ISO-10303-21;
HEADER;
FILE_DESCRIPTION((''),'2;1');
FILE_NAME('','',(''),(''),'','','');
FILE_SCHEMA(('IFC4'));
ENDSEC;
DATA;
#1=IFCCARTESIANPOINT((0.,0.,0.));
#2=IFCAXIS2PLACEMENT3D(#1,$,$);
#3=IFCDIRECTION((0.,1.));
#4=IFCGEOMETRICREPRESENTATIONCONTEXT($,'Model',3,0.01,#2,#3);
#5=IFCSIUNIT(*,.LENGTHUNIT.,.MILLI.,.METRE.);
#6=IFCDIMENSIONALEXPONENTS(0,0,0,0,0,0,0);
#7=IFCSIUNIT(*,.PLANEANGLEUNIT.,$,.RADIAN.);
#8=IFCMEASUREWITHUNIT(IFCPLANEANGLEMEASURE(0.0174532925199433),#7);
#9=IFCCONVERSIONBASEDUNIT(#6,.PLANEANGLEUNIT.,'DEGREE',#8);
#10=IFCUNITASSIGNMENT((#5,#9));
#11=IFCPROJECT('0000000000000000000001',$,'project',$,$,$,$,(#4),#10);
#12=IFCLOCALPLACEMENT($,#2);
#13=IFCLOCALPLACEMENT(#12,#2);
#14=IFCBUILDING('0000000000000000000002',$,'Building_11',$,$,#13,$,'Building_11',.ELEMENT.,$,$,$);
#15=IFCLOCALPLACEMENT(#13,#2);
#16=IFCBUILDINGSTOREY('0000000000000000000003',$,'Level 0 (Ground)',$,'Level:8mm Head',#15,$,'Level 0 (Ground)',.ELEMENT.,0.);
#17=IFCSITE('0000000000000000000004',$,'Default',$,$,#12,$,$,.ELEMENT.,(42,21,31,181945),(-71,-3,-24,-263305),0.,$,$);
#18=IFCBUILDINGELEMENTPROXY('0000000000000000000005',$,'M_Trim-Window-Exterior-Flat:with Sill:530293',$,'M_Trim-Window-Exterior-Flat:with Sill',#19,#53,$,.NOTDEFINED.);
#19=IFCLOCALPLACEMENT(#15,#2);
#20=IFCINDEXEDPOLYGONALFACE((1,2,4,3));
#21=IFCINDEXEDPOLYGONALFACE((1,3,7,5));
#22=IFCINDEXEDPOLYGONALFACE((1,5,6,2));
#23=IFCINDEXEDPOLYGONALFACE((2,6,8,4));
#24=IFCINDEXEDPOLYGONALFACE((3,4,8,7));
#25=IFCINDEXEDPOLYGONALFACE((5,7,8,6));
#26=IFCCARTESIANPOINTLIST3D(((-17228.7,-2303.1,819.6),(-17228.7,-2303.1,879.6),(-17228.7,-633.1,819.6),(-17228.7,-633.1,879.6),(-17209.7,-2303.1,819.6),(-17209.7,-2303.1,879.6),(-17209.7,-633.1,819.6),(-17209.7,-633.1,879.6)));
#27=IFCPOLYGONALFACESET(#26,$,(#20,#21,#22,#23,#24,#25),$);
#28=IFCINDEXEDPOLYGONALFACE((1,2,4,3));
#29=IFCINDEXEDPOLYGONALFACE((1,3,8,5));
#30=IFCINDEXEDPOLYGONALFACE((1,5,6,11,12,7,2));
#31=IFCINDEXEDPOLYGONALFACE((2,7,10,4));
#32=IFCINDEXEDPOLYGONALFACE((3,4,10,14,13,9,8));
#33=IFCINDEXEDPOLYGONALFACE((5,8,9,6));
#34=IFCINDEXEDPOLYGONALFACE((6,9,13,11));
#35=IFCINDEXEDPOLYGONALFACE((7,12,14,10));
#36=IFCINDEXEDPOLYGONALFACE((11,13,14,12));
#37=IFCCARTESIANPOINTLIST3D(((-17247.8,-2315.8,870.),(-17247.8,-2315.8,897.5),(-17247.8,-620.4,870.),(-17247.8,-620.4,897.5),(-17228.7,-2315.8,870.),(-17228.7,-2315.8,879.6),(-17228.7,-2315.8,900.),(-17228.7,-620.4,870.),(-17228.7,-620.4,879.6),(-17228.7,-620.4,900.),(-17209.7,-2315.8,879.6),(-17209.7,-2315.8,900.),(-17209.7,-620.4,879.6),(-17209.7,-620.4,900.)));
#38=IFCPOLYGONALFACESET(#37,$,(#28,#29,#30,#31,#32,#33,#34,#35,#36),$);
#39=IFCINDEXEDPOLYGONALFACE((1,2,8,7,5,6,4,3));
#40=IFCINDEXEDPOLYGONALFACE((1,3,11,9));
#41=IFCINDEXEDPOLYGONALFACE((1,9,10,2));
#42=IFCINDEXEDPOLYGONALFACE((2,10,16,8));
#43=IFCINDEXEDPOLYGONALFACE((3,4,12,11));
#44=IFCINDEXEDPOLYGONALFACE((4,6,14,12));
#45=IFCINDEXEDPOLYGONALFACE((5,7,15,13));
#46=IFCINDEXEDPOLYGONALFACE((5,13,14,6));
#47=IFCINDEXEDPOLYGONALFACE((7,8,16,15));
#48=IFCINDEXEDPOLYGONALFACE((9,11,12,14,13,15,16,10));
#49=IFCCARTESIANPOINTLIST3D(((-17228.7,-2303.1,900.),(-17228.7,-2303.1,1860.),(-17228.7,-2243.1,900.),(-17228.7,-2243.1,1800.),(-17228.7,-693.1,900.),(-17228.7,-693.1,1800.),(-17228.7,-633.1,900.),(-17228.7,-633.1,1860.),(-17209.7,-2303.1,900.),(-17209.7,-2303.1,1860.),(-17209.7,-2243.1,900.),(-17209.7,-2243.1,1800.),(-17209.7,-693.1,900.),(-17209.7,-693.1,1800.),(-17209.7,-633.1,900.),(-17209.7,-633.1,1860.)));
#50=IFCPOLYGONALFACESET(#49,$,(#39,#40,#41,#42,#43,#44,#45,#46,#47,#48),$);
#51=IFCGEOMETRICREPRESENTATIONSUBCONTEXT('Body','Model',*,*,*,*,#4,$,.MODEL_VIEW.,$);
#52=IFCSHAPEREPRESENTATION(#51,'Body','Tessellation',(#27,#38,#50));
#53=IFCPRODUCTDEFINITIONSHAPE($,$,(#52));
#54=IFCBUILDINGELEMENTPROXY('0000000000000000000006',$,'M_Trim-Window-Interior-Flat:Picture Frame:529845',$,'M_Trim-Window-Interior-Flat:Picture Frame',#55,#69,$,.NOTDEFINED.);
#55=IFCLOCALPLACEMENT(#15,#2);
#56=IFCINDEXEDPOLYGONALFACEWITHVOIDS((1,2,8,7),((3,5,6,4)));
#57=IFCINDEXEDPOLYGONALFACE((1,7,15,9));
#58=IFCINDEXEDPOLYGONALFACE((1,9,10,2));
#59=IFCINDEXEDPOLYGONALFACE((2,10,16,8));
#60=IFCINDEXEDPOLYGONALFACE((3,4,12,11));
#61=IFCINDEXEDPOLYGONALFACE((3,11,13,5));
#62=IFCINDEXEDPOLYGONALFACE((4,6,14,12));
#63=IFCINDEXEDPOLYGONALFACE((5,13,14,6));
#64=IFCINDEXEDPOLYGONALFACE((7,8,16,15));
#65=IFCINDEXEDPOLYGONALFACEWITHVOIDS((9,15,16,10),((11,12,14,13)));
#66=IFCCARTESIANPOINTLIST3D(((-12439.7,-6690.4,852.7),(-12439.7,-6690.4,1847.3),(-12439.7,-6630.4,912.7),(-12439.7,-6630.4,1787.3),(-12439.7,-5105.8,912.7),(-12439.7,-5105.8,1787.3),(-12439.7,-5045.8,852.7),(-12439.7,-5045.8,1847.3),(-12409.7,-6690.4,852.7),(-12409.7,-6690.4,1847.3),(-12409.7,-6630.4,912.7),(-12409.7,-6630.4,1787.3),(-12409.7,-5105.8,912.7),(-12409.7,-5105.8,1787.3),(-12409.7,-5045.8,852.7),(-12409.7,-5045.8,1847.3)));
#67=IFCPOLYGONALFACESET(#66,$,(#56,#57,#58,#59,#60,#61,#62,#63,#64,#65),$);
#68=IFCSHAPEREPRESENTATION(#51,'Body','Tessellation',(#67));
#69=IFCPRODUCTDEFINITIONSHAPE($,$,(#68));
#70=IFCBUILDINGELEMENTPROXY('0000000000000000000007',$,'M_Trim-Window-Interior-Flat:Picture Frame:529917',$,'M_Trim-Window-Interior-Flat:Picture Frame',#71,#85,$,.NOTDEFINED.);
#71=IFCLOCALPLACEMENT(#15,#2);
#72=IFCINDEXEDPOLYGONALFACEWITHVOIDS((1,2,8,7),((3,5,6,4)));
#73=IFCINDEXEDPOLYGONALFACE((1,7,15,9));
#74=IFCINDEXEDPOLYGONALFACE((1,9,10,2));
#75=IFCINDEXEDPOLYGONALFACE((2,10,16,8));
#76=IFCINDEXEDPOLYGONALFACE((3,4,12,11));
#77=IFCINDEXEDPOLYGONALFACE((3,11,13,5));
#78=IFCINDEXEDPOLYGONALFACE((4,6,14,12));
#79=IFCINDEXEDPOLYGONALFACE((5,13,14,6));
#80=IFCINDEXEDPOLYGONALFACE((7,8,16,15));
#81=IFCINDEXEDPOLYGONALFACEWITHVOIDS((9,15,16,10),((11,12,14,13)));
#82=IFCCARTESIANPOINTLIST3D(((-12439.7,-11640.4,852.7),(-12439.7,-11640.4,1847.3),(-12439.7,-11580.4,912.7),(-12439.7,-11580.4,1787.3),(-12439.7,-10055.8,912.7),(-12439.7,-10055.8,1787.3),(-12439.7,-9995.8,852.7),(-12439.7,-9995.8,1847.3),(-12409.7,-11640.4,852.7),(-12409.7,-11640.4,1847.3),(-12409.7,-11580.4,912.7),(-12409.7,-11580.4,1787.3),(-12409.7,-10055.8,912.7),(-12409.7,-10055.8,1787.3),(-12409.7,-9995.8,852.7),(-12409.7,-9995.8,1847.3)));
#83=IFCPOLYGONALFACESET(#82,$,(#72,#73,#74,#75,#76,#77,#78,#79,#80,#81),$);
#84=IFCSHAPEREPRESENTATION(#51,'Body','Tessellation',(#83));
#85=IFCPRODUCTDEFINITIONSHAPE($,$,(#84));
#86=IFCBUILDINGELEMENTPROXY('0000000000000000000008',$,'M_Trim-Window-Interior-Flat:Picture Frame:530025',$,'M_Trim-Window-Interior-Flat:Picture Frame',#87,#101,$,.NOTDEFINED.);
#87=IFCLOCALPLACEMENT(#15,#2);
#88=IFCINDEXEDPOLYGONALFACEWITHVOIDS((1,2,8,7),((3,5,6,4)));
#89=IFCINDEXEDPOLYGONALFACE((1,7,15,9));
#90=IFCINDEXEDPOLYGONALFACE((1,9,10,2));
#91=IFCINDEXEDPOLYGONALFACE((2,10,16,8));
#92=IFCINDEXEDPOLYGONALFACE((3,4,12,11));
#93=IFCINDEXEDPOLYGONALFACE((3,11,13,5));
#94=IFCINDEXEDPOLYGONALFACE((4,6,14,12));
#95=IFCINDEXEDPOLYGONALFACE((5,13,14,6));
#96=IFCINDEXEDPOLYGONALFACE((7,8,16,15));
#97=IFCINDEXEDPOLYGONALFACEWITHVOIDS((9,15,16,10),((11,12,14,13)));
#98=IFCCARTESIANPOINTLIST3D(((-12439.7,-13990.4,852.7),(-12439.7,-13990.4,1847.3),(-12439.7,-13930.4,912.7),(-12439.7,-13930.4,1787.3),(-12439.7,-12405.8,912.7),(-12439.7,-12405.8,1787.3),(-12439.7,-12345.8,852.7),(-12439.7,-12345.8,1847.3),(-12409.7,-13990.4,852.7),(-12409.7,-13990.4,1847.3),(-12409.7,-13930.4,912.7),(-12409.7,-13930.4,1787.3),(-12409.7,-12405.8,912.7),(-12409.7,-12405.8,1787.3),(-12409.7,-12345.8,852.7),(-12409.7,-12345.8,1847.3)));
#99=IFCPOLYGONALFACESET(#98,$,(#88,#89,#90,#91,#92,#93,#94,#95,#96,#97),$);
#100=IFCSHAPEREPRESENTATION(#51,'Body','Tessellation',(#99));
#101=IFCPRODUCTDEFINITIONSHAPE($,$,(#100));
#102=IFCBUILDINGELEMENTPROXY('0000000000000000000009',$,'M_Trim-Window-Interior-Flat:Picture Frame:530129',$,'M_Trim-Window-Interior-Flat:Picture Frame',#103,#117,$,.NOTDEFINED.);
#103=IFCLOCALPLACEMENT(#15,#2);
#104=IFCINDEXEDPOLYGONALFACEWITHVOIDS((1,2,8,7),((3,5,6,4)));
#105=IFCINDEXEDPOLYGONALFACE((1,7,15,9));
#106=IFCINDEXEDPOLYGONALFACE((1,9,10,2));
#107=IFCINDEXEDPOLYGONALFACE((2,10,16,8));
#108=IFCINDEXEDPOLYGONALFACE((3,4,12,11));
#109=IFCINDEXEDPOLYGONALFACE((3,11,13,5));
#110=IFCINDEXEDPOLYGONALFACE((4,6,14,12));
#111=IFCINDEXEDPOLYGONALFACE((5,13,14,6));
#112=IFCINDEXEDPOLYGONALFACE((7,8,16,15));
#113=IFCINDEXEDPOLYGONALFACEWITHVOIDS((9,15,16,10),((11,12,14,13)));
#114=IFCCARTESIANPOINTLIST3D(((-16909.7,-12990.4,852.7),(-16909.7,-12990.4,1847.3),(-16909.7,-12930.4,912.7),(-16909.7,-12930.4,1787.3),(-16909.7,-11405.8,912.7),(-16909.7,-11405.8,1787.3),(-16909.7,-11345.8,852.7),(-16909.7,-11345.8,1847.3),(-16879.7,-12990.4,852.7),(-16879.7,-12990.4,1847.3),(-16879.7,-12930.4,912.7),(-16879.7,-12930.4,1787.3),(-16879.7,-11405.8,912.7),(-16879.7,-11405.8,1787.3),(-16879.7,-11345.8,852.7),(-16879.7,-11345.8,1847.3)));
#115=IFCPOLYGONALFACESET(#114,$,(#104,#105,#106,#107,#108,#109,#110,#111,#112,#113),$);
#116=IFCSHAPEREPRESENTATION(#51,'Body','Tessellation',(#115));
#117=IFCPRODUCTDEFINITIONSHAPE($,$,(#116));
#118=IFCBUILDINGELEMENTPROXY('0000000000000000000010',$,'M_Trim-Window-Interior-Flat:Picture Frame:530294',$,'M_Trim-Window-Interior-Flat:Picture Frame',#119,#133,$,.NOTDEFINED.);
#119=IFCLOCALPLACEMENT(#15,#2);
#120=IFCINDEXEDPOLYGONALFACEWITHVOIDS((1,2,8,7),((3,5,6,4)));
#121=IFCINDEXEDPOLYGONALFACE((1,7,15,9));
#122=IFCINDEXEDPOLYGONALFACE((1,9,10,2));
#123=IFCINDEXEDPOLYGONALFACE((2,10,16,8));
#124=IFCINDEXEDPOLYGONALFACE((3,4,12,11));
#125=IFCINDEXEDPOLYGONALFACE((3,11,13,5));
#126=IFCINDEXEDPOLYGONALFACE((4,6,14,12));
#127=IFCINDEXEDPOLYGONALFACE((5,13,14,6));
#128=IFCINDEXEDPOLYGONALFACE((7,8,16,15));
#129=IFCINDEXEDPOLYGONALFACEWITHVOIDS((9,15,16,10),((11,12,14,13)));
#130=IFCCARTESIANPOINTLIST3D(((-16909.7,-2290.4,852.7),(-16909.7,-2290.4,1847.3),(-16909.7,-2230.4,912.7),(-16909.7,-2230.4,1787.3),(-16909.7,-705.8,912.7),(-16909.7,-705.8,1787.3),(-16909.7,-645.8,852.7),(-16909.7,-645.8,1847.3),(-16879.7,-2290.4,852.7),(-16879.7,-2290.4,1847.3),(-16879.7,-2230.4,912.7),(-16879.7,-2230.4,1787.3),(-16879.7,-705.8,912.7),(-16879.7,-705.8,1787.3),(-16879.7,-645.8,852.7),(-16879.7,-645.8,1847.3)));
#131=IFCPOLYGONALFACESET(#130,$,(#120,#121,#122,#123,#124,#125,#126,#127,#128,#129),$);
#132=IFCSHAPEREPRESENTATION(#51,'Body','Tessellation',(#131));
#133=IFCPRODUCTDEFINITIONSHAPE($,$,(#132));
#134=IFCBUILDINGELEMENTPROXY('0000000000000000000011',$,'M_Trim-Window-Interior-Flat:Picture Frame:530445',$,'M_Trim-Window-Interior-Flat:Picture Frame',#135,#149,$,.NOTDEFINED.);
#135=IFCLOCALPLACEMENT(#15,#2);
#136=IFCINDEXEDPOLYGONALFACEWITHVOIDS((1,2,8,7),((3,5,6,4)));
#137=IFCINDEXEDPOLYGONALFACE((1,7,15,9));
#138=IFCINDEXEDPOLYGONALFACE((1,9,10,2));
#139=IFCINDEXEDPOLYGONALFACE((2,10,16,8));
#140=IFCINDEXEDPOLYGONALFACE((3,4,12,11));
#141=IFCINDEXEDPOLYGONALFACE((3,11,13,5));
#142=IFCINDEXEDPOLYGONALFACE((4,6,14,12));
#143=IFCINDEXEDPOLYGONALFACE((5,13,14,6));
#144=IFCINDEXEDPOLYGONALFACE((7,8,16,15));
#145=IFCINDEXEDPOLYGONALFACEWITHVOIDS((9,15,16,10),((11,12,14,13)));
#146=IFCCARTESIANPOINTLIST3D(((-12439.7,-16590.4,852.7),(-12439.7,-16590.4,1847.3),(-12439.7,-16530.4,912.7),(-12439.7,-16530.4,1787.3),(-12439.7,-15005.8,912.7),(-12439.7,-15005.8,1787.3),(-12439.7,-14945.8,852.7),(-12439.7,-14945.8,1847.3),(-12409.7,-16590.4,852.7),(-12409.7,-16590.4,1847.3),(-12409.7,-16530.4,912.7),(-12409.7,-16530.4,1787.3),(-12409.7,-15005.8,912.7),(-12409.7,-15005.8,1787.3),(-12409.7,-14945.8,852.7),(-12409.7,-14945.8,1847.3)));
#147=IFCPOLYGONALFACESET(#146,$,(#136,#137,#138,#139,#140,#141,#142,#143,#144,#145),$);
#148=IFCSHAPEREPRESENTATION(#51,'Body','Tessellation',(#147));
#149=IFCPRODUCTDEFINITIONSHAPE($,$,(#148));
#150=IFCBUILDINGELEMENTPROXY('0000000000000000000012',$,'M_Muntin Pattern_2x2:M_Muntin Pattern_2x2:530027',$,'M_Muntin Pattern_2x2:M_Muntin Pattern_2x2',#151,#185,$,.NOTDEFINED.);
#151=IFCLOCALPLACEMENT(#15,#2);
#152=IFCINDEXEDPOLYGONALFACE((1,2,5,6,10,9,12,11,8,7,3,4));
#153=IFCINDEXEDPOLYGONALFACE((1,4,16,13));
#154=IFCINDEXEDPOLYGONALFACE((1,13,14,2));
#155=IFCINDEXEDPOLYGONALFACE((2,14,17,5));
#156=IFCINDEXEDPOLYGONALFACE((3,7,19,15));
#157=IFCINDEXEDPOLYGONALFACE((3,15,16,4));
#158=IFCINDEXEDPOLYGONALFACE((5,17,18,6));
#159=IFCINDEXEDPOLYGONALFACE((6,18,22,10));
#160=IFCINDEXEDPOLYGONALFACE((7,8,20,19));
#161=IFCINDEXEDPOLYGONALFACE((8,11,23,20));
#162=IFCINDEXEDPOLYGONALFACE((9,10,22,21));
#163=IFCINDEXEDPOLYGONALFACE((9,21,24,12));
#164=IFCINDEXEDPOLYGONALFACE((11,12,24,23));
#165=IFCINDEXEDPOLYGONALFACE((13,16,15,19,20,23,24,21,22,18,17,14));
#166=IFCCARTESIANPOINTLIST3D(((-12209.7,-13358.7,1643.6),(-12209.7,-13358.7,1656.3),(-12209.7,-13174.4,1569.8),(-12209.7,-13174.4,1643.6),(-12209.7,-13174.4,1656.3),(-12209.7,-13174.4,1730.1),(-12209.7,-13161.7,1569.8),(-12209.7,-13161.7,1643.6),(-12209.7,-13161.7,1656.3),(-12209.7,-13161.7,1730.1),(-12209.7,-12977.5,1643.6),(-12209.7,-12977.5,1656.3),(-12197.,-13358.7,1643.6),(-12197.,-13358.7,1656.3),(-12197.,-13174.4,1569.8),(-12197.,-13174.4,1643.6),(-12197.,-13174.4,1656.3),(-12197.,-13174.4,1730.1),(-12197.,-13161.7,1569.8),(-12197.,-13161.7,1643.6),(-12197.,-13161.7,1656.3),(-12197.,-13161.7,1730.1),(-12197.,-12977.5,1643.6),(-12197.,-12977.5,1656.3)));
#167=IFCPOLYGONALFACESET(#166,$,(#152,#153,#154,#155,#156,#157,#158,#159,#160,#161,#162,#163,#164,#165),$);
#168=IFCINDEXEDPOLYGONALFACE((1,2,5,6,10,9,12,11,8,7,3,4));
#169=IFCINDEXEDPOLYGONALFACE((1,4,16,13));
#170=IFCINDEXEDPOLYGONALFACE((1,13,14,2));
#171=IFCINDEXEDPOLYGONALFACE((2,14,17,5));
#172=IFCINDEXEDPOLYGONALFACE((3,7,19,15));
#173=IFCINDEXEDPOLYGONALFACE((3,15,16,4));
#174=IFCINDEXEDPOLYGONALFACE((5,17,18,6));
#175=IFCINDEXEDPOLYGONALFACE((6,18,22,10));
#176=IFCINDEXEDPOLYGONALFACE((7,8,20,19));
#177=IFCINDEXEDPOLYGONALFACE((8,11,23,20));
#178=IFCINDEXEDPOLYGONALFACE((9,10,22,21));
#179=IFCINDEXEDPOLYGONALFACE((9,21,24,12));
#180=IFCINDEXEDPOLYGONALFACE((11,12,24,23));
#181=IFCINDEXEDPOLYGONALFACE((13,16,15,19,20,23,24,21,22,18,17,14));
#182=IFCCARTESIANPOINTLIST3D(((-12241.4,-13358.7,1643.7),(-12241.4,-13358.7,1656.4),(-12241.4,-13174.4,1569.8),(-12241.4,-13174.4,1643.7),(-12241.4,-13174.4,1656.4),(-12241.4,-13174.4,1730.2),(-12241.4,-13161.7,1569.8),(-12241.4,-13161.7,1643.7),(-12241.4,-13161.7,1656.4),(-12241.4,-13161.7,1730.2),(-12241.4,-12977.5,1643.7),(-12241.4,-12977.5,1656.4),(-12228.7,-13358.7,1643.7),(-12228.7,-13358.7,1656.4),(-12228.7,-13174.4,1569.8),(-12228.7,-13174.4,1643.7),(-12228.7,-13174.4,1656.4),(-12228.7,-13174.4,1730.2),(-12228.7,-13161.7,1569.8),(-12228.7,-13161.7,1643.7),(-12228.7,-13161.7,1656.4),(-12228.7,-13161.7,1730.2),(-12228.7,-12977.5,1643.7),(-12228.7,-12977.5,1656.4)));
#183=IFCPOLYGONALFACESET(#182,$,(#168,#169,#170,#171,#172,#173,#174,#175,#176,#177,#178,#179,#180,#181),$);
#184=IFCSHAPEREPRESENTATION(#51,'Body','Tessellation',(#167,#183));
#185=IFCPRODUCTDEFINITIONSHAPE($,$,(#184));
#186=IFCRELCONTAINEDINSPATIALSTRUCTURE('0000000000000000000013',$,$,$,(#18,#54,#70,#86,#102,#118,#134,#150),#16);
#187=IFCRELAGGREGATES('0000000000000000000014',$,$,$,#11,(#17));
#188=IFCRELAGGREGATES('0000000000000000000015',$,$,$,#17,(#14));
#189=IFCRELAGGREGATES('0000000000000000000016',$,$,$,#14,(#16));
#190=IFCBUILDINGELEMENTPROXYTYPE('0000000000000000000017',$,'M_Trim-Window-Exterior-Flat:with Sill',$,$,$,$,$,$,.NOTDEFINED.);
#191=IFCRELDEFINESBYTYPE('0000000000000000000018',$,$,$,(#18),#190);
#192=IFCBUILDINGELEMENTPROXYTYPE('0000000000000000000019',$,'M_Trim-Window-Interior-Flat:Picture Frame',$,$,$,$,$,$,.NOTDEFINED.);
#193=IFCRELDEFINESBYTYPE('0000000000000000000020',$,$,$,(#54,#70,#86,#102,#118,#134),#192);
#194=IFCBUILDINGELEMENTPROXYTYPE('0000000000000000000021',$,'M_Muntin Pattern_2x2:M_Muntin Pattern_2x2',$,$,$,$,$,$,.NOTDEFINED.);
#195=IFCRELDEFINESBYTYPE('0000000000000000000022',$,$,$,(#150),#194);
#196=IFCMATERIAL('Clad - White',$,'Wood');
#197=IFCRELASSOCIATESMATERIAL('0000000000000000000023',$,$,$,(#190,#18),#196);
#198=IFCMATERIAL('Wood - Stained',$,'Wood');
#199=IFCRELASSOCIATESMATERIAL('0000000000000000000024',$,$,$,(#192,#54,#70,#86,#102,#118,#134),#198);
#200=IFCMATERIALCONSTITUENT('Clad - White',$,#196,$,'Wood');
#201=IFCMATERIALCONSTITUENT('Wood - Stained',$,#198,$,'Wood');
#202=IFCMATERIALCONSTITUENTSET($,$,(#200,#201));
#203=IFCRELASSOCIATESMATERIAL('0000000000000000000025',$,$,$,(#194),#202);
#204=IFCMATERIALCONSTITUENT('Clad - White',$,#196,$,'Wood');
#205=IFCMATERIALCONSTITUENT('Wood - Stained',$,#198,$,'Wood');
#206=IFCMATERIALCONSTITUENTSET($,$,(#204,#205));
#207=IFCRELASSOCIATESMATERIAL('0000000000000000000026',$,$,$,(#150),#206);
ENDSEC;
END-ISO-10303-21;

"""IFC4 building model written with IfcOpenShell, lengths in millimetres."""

from ifc_helpers import new_model, entity, si_unit, converted_unit, direction, frame, origin, place, context, subcontext, project, spatial, indexed_curve, outline, extrude, source, transform, mapped, material, constituent, constituent_set, type_object, type_shapes, element, save


model = new_model("IFC4")

# Units and contexts
model_context = context("Model", 3, precision=0.01, world=origin(), true_north=direction((0.0, 1.0)))
body_context = subcontext(model_context, "Body", "Model", "MODEL_VIEW")
ifc_project = project(units=[si_unit("LENGTHUNIT", "METRE", prefix="MILLI"), converted_unit("PLANEANGLEUNIT", "DEGREE", entity("IfcPlaneAngleMeasure", 0.0174532925199433), si_unit("PLANEANGLEUNIT", "RADIAN"), dimensions=[0, 0, 0, 0, 0, 0, 0])], contexts=[model_context])

# Site, building, storey
site_placement = place(None, origin())
site = spatial("IfcSite", under=ifc_project, at=site_placement, Name="Default", CompositionType="ELEMENT", RefLatitude=(42, 21, 31, 181945), RefLongitude=(-71, -3, -24, -263305), RefElevation=0.0)
building_placement = place(site_placement, origin())
building = spatial("IfcBuilding", under=site, at=building_placement, Name="Building_11", LongName="Building_11", CompositionType="ELEMENT")
storey_placement = place(building_placement, origin())
storey = spatial("IfcBuildingStorey", under=building, at=storey_placement, Name="Level 0 (Ground)", ObjectType="Level:8mm Head", LongName="Level 0 (Ground)", CompositionType="ELEMENT", Elevation=0.0)

# Building element proxies
ifc_material_1 = material(Name="Clad - White", Category="Wood")
ifc_material_2 = material(Name="Wood - Stained", Category="Wood")
building_element_proxy_type_1 = type_object("IfcBuildingElementProxyType", Name="M_Trim-Window-Exterior-Flat:with Sill", PredefinedType="NOTDEFINED", material=ifc_material_1)
shared_shape_1 = source(origin(), body_context, "Body", "SweptSolid", [
    extrude(outline(indexed_curve([(-835.0, -30.0), (835.0, -30.0), (835.0, 30.0), (-835.0, 30.0), (-835.0, -30.0)], self_intersect=False)), frame((0.0, -950.4, 0.0), z_axis=(0.0, 0.0, 1.0), x_axis=(-1.0, 0.0, 0.0)), (0.0, 0.0, 1.0), 19.1),
    extrude(outline(indexed_curve([(-19.0, -15.2), (0.0, -15.2), (0.0, -5.7), (19.0, -5.7), (19.0, 14.8), (0.0, 14.8), (-19.0, 12.3), (-19.0, -15.2)], self_intersect=False)), frame((-847.7, -914.8, 19.0), z_axis=(1.0, 0.0, 0.0), x_axis=(0.0, 0.0, -1.0)), (0.0, 0.0, 1.0), 1695.4),
    extrude(outline(indexed_curve([(-495.0, -835.0), (465.0, -835.0), (465.0, -775.0), (-435.0, -775.0), (-435.0, 775.0), (465.0, 775.0), (465.0, 835.0), (-495.0, 835.0), (-495.0, -835.0)], self_intersect=False)), frame((0.0, -435.0, 0.0), z_axis=(0.0, 0.0, 1.0), x_axis=(0.0, -1.0, 0.0)), (0.0, 0.0, 1.0), 19.1),
])
type_shapes(building_element_proxy_type_1, [shared_shape_1])
for number, where, z_axis, x_axis, name in (
    (1, (-17209.7, -1468.1, 1800.0), (-1.0, 0.0, 0.0), (0.0, -1.0, 0.0), "M_Trim-Window-Exterior-Flat:with Sill:530293"),
):
    element("IfcBuildingElementProxy", number, at=place(storey_placement, frame(where, z_axis=z_axis, x_axis=x_axis)), inside=storey, type_object=building_element_proxy_type_1, material=ifc_material_1, Name=name, ObjectType="M_Trim-Window-Exterior-Flat:with Sill", PredefinedType="NOTDEFINED", context=body_context, shape_type="MappedRepresentation", body=[
        mapped(shared_shape_1, transform((0.0, 0.0, 0.0), scale=1.0)),
    ])
building_element_proxy_type_2 = type_object("IfcBuildingElementProxyType", Name="M_Trim-Window-Interior-Flat:Picture Frame", PredefinedType="NOTDEFINED", material=ifc_material_2)
shared_shape_2 = source(origin(), body_context, "Body", "SweptSolid", [
    extrude(outline(indexed_curve([(-822.3, -497.3), (822.3, -497.3), (822.3, 497.3), (-822.3, 497.3), (-822.3, -497.3)], self_intersect=False), holes=[indexed_curve([(-762.3, -437.3), (-762.3, 437.3), (762.3, 437.3), (762.3, -437.3), (-762.3, -437.3)], self_intersect=False)]), frame((0.0, -450.0, 0.0), z_axis=(0.0, 0.0, 1.0), x_axis=(-1.0, 0.0, 0.0)), (0.0, 0.0, 1.0), 30.0),
])
type_shapes(building_element_proxy_type_2, [shared_shape_2])
for number, where, z_axis, x_axis, name in (
    (2, (-12409.7, -5868.1, 1800.0), (-1.0, 0.0, 0.0), (0.0, -1.0, 0.0), "M_Trim-Window-Interior-Flat:Picture Frame:529845"),
    (3, (-12409.7, -10818.1, 1800.0), (-1.0, 0.0, 0.0), (0.0, -1.0, 0.0), "M_Trim-Window-Interior-Flat:Picture Frame:529917"),
    (4, (-12409.7, -13168.1, 1800.0), (-1.0, 0.0, 0.0), (0.0, -1.0, 0.0), "M_Trim-Window-Interior-Flat:Picture Frame:530025"),
    (5, (-16909.7, -12168.1, 1800.0), (1.0, 0.0, 0.0), (0.0, 1.0, 0.0), "M_Trim-Window-Interior-Flat:Picture Frame:530129"),
    (6, (-16909.7, -1468.1, 1800.0), (1.0, 0.0, 0.0), (0.0, 1.0, 0.0), "M_Trim-Window-Interior-Flat:Picture Frame:530294"),
    (7, (-12409.7, -15768.1, 1800.0), (-1.0, 0.0, 0.0), (0.0, -1.0, 0.0), "M_Trim-Window-Interior-Flat:Picture Frame:530445"),
):
    element("IfcBuildingElementProxy", number, at=place(storey_placement, frame(where, z_axis=z_axis, x_axis=x_axis)), inside=storey, type_object=building_element_proxy_type_2, material=ifc_material_2, Name=name, ObjectType="M_Trim-Window-Interior-Flat:Picture Frame", PredefinedType="NOTDEFINED", context=body_context, shape_type="MappedRepresentation", body=[
        mapped(shared_shape_2, transform((0.0, 0.0, 0.0), scale=1.0)),
    ])
ifc_constituent_1 = constituent(ifc_material_1, Name="Clad - White", Category="Wood")
ifc_constituent_2 = constituent(ifc_material_2, Name="Wood - Stained", Category="Wood")
ifc_constituent_set_1 = constituent_set(constituents=[ifc_constituent_1, ifc_constituent_2])
ifc_constituent_3 = constituent(ifc_material_1, Name="Clad - White", Category="Wood")
ifc_constituent_4 = constituent(ifc_material_2, Name="Wood - Stained", Category="Wood")
ifc_constituent_set_2 = constituent_set(constituents=[ifc_constituent_3, ifc_constituent_4])
building_element_proxy_type_3 = type_object("IfcBuildingElementProxyType", Name="M_Muntin Pattern_2x2:M_Muntin Pattern_2x2", PredefinedType="NOTDEFINED", material=ifc_constituent_set_2)
shared_shape_3 = source(origin(), body_context, "Body", "SweptSolid", [
    extrude(outline(indexed_curve([(6.4, -6.4), (80.1, -6.4), (80.1, 6.3), (6.4, 6.3), (6.4, 190.6), (-6.3, 190.6), (-6.3, 6.3), (-80.2, 6.3), (-80.2, -6.4), (-6.3, -6.4), (-6.3, -190.6), (6.4, -190.6), (6.4, -6.4)], self_intersect=False)), frame((0.0, 9.5, 80.1), z_axis=(0.0, 1.0, 0.0), x_axis=(0.0, 0.0, 1.0)), (0.0, 0.0, 1.0), 12.7),
    extrude(outline(indexed_curve([(6.4, -6.4), (80.2, -6.4), (80.2, 6.3), (6.4, 6.3), (6.4, 190.6), (-6.3, 190.6), (-6.3, 6.3), (-80.2, 6.3), (-80.2, -6.4), (-6.3, -6.4), (-6.3, -190.6), (6.4, -190.6), (6.4, -6.4)], self_intersect=False)), frame((0.0, -22.2, 80.2), z_axis=(0.0, 1.0, 0.0), x_axis=(0.0, 0.0, 1.0)), (0.0, 0.0, 1.0), 12.7),
])
type_shapes(building_element_proxy_type_3, [shared_shape_3])
proxy_1_placement = place(storey_placement, frame((-12219.2, -13168.1, 1569.8), z_axis=(0.0, 0.0, 1.0), x_axis=(0.0, -1.0, 0.0)))
element("IfcBuildingElementProxy", 8, at=proxy_1_placement, inside=storey, type_object=building_element_proxy_type_3, material=ifc_constituent_set_1, Name="M_Muntin Pattern_2x2:M_Muntin Pattern_2x2:530027", ObjectType="M_Muntin Pattern_2x2:M_Muntin Pattern_2x2", PredefinedType="NOTDEFINED", context=body_context, shape_type="MappedRepresentation", body=[
    mapped(shared_shape_3, transform((0.0, 0.0, 0.0), scale=1.0)),
])

save(model, "model.ifc")
